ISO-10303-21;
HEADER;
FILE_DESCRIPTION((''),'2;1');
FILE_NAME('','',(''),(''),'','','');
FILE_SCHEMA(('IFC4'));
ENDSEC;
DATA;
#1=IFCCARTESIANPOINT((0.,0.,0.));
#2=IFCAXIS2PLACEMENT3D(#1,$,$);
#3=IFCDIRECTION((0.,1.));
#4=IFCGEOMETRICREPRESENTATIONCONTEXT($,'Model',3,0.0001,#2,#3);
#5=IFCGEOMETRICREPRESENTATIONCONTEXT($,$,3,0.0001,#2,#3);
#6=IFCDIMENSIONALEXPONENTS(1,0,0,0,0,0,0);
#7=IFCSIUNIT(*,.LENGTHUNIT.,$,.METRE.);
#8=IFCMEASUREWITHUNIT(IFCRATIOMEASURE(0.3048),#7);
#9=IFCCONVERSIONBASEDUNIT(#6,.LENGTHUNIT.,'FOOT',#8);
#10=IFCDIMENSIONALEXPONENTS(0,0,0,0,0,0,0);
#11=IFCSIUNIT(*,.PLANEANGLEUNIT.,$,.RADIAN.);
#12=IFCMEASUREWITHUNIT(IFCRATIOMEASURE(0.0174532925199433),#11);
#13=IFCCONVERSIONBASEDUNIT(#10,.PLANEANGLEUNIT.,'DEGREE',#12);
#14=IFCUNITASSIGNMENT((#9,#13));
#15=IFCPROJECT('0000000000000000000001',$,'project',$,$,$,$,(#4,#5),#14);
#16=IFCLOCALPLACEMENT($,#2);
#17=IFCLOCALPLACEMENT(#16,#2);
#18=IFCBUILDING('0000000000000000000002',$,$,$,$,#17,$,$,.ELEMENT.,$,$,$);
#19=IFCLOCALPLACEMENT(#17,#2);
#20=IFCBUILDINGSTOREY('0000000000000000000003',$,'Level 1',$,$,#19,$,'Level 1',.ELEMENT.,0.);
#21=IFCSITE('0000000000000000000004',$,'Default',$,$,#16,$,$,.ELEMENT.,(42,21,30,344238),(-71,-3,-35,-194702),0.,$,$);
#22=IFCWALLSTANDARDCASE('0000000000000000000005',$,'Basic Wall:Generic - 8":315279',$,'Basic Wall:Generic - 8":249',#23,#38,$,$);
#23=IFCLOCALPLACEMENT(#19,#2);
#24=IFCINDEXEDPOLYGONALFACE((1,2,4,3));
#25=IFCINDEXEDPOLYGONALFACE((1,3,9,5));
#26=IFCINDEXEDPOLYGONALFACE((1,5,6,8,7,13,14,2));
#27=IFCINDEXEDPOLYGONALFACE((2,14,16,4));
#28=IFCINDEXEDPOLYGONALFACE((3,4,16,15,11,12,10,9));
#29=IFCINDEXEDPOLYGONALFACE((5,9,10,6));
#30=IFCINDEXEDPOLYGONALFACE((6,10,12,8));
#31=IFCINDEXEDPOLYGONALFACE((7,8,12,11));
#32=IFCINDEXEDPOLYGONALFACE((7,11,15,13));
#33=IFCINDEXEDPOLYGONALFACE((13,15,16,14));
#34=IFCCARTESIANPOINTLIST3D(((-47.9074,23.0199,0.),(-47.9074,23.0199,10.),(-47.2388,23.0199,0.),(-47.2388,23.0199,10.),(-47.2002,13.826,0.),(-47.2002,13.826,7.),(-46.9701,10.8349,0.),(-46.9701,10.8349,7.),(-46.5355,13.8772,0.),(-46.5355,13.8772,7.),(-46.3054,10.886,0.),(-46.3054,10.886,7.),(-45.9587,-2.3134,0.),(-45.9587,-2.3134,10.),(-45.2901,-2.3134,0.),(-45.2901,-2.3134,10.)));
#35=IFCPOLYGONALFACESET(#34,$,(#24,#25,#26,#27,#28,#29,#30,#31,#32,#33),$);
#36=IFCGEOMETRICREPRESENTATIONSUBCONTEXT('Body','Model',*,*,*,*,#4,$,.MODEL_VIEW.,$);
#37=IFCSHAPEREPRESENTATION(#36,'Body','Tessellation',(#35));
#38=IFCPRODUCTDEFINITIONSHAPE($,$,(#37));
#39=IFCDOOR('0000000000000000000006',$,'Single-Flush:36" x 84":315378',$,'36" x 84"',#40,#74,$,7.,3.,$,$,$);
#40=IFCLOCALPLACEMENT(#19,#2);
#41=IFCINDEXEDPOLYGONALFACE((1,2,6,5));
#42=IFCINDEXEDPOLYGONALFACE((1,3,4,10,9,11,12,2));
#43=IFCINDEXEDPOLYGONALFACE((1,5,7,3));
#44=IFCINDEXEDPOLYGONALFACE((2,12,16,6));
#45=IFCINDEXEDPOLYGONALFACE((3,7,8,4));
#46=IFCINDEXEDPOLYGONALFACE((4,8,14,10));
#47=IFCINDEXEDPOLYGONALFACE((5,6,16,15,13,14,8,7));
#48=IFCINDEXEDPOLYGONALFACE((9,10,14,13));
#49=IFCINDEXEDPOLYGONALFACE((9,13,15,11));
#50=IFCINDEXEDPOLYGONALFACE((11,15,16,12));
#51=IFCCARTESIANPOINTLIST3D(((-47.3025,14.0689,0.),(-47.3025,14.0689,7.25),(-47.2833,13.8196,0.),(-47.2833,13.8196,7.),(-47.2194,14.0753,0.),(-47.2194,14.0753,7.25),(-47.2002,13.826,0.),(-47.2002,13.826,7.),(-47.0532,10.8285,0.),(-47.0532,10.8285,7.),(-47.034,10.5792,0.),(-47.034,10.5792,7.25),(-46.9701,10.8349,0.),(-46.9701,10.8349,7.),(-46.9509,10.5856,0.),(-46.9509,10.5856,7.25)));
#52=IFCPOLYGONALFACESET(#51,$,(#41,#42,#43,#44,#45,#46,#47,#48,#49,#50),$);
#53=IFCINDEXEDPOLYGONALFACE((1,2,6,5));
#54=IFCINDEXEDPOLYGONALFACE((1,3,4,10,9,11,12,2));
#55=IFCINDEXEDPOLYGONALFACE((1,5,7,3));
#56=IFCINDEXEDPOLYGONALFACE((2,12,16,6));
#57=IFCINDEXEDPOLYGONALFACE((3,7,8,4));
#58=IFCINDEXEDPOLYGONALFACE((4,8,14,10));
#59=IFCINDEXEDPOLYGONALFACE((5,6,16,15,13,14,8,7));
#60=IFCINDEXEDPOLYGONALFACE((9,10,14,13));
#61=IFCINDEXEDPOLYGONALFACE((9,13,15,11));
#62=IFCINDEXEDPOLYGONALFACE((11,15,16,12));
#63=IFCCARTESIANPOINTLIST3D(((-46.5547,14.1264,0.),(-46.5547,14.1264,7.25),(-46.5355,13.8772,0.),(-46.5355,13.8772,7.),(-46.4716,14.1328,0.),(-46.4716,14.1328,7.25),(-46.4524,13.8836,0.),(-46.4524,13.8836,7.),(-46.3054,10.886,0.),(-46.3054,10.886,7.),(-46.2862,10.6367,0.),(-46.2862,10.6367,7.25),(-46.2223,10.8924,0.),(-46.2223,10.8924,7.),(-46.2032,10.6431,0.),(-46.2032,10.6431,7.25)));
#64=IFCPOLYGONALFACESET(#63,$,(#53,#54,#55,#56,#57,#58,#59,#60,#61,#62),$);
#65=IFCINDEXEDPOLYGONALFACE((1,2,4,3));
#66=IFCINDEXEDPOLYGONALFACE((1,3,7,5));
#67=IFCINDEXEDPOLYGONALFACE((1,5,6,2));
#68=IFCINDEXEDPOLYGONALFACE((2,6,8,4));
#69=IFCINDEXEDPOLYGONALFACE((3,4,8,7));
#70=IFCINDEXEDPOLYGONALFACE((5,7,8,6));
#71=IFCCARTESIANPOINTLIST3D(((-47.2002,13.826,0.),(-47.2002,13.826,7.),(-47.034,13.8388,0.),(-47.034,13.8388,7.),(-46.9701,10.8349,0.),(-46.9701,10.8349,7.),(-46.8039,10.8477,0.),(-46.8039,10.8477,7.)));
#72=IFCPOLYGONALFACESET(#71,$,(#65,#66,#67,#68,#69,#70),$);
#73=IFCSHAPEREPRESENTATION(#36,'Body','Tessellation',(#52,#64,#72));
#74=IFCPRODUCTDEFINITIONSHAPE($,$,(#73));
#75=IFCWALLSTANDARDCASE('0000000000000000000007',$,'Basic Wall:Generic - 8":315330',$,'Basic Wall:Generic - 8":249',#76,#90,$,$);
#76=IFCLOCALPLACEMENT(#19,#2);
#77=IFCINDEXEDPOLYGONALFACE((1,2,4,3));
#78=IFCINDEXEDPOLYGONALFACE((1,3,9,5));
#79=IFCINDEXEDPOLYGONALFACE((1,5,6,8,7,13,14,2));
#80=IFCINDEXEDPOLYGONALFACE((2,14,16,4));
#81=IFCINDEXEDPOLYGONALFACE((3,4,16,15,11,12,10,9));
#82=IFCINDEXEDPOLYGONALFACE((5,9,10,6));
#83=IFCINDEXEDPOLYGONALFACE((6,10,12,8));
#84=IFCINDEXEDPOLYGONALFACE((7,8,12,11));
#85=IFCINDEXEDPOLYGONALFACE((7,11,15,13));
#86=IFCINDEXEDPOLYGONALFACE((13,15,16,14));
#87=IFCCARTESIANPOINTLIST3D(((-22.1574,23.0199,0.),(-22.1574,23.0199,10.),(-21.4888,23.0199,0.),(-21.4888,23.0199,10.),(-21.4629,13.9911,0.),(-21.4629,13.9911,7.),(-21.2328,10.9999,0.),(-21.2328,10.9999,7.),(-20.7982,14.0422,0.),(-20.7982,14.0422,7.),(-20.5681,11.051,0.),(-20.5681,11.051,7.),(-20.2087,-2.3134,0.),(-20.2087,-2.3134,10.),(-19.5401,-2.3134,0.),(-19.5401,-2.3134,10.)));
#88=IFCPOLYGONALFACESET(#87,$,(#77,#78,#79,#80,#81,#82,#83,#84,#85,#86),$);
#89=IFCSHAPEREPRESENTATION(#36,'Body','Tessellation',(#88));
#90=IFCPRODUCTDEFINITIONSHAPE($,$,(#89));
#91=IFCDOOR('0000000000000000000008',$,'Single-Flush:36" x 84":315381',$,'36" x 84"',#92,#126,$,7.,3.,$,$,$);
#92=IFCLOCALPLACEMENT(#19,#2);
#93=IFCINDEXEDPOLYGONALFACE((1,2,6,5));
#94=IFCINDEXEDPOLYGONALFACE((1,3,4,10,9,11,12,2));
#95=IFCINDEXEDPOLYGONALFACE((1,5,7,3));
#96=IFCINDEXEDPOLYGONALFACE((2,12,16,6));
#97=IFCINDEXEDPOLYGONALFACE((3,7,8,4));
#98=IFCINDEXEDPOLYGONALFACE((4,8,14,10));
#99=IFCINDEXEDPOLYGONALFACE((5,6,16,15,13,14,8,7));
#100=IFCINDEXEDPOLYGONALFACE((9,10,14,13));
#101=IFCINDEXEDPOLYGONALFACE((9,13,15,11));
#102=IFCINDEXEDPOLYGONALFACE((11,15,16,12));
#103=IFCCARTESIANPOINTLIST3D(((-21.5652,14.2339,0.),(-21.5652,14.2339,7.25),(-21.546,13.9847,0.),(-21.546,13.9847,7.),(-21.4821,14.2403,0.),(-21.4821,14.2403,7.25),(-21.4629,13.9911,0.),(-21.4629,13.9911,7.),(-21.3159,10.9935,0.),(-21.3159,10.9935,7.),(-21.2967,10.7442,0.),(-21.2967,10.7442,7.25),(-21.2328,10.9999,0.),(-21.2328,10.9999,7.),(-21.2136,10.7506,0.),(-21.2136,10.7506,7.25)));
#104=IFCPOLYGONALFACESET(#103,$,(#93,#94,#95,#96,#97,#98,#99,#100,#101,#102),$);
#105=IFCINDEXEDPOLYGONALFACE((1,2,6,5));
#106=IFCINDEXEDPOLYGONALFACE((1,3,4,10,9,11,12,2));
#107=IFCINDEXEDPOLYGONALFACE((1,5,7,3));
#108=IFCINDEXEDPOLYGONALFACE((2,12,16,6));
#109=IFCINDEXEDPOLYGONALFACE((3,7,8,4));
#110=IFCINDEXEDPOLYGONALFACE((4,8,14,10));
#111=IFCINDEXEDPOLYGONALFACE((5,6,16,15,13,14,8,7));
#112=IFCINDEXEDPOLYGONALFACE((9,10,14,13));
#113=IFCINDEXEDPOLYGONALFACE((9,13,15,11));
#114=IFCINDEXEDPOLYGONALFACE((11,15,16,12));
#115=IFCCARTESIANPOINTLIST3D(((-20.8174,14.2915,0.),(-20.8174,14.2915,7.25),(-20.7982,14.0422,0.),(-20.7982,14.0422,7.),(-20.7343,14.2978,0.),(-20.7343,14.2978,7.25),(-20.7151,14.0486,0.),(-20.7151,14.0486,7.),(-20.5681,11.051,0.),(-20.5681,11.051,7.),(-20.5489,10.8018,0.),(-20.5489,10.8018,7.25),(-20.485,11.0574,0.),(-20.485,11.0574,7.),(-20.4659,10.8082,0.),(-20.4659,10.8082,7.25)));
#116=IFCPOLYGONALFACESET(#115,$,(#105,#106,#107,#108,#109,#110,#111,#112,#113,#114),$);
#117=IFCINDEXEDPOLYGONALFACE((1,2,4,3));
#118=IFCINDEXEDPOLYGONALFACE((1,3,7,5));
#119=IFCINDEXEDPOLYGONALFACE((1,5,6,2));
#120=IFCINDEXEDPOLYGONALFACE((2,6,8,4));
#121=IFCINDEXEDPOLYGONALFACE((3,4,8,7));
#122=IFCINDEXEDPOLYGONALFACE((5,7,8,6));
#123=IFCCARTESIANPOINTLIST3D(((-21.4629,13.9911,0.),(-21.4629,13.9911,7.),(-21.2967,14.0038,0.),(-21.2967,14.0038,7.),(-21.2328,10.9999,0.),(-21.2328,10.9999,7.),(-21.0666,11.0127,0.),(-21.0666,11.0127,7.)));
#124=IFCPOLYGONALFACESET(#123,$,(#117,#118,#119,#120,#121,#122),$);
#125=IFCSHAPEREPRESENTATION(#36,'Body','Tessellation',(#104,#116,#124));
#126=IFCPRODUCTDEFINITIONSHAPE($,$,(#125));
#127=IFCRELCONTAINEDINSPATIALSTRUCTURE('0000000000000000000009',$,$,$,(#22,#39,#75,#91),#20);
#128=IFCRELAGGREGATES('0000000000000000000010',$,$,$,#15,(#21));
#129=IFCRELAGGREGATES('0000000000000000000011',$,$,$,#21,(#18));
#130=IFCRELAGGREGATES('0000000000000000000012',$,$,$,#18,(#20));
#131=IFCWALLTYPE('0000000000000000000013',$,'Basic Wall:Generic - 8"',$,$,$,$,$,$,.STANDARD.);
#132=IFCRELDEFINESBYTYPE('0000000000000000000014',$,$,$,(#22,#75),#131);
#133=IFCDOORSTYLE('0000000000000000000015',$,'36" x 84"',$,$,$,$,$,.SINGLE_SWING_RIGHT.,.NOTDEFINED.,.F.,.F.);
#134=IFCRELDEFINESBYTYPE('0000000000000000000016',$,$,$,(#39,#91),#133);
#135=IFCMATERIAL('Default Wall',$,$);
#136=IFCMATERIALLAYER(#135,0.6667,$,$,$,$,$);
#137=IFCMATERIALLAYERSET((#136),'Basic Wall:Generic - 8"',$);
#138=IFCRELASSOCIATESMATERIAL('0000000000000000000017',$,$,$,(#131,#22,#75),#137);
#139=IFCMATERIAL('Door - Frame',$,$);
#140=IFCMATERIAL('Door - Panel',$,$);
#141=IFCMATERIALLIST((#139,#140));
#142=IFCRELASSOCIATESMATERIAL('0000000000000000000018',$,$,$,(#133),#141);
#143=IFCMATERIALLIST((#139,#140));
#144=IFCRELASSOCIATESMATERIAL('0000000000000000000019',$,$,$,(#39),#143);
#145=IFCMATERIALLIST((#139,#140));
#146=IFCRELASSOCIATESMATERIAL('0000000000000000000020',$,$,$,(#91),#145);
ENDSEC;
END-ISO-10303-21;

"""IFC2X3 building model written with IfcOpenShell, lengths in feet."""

from ifc_helpers import new_model, entity, si_unit, converted_unit, direction, frame, frame_2d, origin, place, context, subcontext, project, spatial, polyline, rectangle, outline, extrude, clip, bounded_halfspace, source, transform, mapped, material, material_list, layer, layer_set, layer_usage, type_object, type_shapes, element, fill, save


model = new_model("IFC2X3")

# Units and contexts
model_context = context("Model", 3, precision=0.0001, world=origin(), true_north=direction((0.0, 1.0)))
context_of_model = context(None, 3, precision=0.0001, world=origin(), true_north=direction((0.0, 1.0)))
body_context = subcontext(model_context, "Body", "Model", "MODEL_VIEW")
ifc_project = project(units=[converted_unit("LENGTHUNIT", "FOOT", entity("IfcRatioMeasure", 0.3048), si_unit("LENGTHUNIT", "METRE"), dimensions=[1, 0, 0, 0, 0, 0, 0]), converted_unit("PLANEANGLEUNIT", "DEGREE", entity("IfcRatioMeasure", 0.0174532925199433), si_unit("PLANEANGLEUNIT", "RADIAN"), dimensions=[0, 0, 0, 0, 0, 0, 0])], contexts=[model_context, context_of_model])

# Site, building, storey
site_placement = place(None, origin())
site = spatial("IfcSite", under=ifc_project, at=site_placement, Name="Default", CompositionType="ELEMENT", RefLatitude=(42, 21, 30, 344238), RefLongitude=(-71, -3, -35, -194702), RefElevation=0.0)
building_placement = place(site_placement, origin())
building = spatial("IfcBuilding", under=site, at=building_placement, CompositionType="ELEMENT")
storey_placement = place(building_placement, origin())
storey = spatial("IfcBuildingStorey", under=building, at=storey_placement, Name="Level 1", LongName="Level 1", CompositionType="ELEMENT", Elevation=0.0)

# Shared definitions
ifc_material_1 = material(Name="Default Wall")
ifc_layer_1 = layer(ifc_material_1, 0.6667)
ifc_layer_set_1 = layer_set([ifc_layer_1], Name="Basic Wall:Generic - 8\"")
wall_type = type_object("IfcWallType", Name="Basic Wall:Generic - 8\"", PredefinedType="STANDARD", material=ifc_layer_set_1)
ifc_material_2 = material(Name="Door - Frame")
ifc_material_3 = material(Name="Door - Panel")
ifc_material_list_1 = material_list([ifc_material_2, ifc_material_3])
door_style = type_object("IfcDoorStyle", Name="36\" x 84\"", ConstructionType="NOTDEFINED", OperationType="SINGLE_SWING_RIGHT", ParameterTakesPrecedence=False, Sizeable=False, material=ifc_material_list_1)
shared_shape_1 = source(origin(), body_context, "Body", "SweptSolid", [
    extrude(outline(polyline([(-1.75, -3.6875), (1.75, -3.6875), (1.75, 3.5625), (1.5, 3.5625), (1.5, -3.4375), (-1.5, -3.4375), (-1.5, 3.5625), (-1.75, 3.5625), (-1.75, -3.6875)])), frame((1.5, 0.6667, 3.5625), z_axis=(0.0, 1.0, 0.0), x_axis=(1.0, 0.0, 0.0)), (0.0, 0.0, 1.0), 0.0833),
    extrude(outline(polyline([(-3.6875, -1.75), (3.5625, -1.75), (3.5625, -1.5), (-3.4375, -1.5), (-3.4375, 1.5), (3.5625, 1.5), (3.5625, 1.75), (-3.6875, 1.75), (-3.6875, -1.75)])), frame((1.5, -0.0833, 3.5625), z_axis=(0.0, 1.0, 0.0), x_axis=(0.0, 0.0, -1.0)), (0.0, 0.0, 1.0), 0.0833),
    extrude(rectangle(XDim=0.1667, YDim=3.0, at=frame_2d((0.0, 0.0), x_axis=(1.0, 0.0))), frame((1.5, 0.5833, 0.0), z_axis=(0.0, 0.0, 1.0), x_axis=(0.0, 1.0, 0.0)), (0.0, 0.0, 1.0), 7.0),
])
type_shapes(door_style, [shared_shape_1])

# Walls, openings, doors
ifc_layer_usage_1 = layer_usage(ifc_layer_set_1, "AXIS2", "NEGATIVE", 0.3333)
wall_1_placement = place(storey_placement, frame((-45.6224, -2.339, 0.0), z_axis=(0.0, 0.0, 1.0), x_axis=(-0.076696, 0.997054, 0.0)))
wall_1 = element("IfcWallStandardCase", 1, at=wall_1_placement, inside=storey, type_object=wall_type, material=ifc_layer_usage_1, Name="Basic Wall:Generic - 8\":315279", ObjectType="Basic Wall:Generic - 8\":249", context=body_context, shape_type="Clipping", body=[
    clip(extrude(outline(polyline([(0.0, -0.3333), (25.4082, -0.3333), (25.4595, 0.3333), (0.0513, 0.3333), (0.0, -0.3333)])), origin(), (0.0, 0.0, 1.0), 10.0), bounded_halfspace(frame((0.0, -0.3333, 10.0), z_axis=(0.0, 0.0, 1.0), x_axis=(-0.076696, -0.997054, 0.0)), False, frame((0.0, -0.3333, 10.0)), polyline([(0.0, 0.0), (25.4082, 0.0), (25.4595, 0.6667), (0.0513, 0.6667), (0.0, 0.0)]))),
])
opening_1_placement = place(wall_1_placement, frame((13.2384, -0.3333, 0.0)))
opening_1 = element("IfcOpeningElement", 2, at=opening_1_placement, cuts=wall_1, ObjectType="Opening", context=body_context, shape_type="SweptSolid", body=[
    extrude(rectangle(XDim=3.0, YDim=7.0, at=frame_2d((3.5, 1.5), x_axis=(0.0, 1.0))), frame((0.0, 0.0, 0.0), z_axis=(0.0, 1.0, 0.0), x_axis=(0.0, 0.0, 1.0)), (0.0, 0.0, 1.0), 0.6667),
])
ifc_material_list_2 = material_list([ifc_material_2, ifc_material_3])
door_1_placement = place(opening_1_placement, origin())
door_1 = element("IfcDoor", 3, at=door_1_placement, inside=storey, type_object=door_style, material=ifc_material_list_2, Name="Single-Flush:36\" x 84\":315378", ObjectType="36\" x 84\"", OverallHeight=7.0, OverallWidth=3.0, context=body_context, shape_type="MappedRepresentation", body=[
    mapped(shared_shape_1, transform((0.0, 0.0, 0.0), scale=1.0)),
])
fill(opening_1, door_1)
ifc_layer_usage_2 = layer_usage(ifc_layer_set_1, "AXIS2", "NEGATIVE", 0.3333)
wall_2_placement = place(storey_placement, frame((-21.8251, 23.0455, 0.0), z_axis=(0.0, 0.0, 1.0), x_axis=(0.076696, -0.997054, 0.0)))
wall_2 = element("IfcWallStandardCase", 4, at=wall_2_placement, inside=storey, type_object=wall_type, material=ifc_layer_usage_2, Name="Basic Wall:Generic - 8\":315330", ObjectType="Basic Wall:Generic - 8\":249", context=body_context, shape_type="Clipping", body=[
    clip(extrude(outline(polyline([(0.0, -0.3333), (25.4082, -0.3333), (25.4595, 0.3333), (0.0513, 0.3333), (0.0, -0.3333)])), origin(), (0.0, 0.0, 1.0), 10.0), bounded_halfspace(frame((0.0, -0.3333, 10.0), z_axis=(0.0, 0.0, 1.0), x_axis=(0.076696, 0.997054, 0.0)), False, frame((0.0, -0.3333, 10.0)), polyline([(0.0, 0.0), (25.4082, 0.0), (25.4595, 0.6667), (0.0513, 0.6667), (0.0, 0.0)]))),
])
opening_2_placement = place(wall_2_placement, frame((12.0555, 0.3333, 0.0)))
opening_2 = element("IfcOpeningElement", 5, at=opening_2_placement, cuts=wall_2, ObjectType="Opening", context=body_context, shape_type="SweptSolid", body=[
    extrude(rectangle(XDim=3.0, YDim=7.0, at=frame_2d((3.5, 1.5), x_axis=(0.0, 1.0))), frame((0.0, 0.0, 0.0), z_axis=(0.0, -1.0, 0.0), x_axis=(0.0, 0.0, 1.0)), (0.0, 0.0, 1.0), 0.6667),
])
ifc_material_list_3 = material_list([ifc_material_2, ifc_material_3])
door_2_placement = place(opening_2_placement, frame((0.0, 0.0, 0.0), z_axis=(0.0, 0.0, 1.0), x_axis=(-1.0, 0.0, 0.0)))
door_2 = element("IfcDoor", 6, at=door_2_placement, inside=storey, type_object=door_style, material=ifc_material_list_3, Name="Single-Flush:36\" x 84\":315381", ObjectType="36\" x 84\"", OverallHeight=7.0, OverallWidth=3.0, context=body_context, shape_type="MappedRepresentation", body=[
    mapped(shared_shape_1, transform((0.0, 0.0, 0.0), scale=1.0)),
])
fill(opening_2, door_2)

save(model, "model.ifc")
